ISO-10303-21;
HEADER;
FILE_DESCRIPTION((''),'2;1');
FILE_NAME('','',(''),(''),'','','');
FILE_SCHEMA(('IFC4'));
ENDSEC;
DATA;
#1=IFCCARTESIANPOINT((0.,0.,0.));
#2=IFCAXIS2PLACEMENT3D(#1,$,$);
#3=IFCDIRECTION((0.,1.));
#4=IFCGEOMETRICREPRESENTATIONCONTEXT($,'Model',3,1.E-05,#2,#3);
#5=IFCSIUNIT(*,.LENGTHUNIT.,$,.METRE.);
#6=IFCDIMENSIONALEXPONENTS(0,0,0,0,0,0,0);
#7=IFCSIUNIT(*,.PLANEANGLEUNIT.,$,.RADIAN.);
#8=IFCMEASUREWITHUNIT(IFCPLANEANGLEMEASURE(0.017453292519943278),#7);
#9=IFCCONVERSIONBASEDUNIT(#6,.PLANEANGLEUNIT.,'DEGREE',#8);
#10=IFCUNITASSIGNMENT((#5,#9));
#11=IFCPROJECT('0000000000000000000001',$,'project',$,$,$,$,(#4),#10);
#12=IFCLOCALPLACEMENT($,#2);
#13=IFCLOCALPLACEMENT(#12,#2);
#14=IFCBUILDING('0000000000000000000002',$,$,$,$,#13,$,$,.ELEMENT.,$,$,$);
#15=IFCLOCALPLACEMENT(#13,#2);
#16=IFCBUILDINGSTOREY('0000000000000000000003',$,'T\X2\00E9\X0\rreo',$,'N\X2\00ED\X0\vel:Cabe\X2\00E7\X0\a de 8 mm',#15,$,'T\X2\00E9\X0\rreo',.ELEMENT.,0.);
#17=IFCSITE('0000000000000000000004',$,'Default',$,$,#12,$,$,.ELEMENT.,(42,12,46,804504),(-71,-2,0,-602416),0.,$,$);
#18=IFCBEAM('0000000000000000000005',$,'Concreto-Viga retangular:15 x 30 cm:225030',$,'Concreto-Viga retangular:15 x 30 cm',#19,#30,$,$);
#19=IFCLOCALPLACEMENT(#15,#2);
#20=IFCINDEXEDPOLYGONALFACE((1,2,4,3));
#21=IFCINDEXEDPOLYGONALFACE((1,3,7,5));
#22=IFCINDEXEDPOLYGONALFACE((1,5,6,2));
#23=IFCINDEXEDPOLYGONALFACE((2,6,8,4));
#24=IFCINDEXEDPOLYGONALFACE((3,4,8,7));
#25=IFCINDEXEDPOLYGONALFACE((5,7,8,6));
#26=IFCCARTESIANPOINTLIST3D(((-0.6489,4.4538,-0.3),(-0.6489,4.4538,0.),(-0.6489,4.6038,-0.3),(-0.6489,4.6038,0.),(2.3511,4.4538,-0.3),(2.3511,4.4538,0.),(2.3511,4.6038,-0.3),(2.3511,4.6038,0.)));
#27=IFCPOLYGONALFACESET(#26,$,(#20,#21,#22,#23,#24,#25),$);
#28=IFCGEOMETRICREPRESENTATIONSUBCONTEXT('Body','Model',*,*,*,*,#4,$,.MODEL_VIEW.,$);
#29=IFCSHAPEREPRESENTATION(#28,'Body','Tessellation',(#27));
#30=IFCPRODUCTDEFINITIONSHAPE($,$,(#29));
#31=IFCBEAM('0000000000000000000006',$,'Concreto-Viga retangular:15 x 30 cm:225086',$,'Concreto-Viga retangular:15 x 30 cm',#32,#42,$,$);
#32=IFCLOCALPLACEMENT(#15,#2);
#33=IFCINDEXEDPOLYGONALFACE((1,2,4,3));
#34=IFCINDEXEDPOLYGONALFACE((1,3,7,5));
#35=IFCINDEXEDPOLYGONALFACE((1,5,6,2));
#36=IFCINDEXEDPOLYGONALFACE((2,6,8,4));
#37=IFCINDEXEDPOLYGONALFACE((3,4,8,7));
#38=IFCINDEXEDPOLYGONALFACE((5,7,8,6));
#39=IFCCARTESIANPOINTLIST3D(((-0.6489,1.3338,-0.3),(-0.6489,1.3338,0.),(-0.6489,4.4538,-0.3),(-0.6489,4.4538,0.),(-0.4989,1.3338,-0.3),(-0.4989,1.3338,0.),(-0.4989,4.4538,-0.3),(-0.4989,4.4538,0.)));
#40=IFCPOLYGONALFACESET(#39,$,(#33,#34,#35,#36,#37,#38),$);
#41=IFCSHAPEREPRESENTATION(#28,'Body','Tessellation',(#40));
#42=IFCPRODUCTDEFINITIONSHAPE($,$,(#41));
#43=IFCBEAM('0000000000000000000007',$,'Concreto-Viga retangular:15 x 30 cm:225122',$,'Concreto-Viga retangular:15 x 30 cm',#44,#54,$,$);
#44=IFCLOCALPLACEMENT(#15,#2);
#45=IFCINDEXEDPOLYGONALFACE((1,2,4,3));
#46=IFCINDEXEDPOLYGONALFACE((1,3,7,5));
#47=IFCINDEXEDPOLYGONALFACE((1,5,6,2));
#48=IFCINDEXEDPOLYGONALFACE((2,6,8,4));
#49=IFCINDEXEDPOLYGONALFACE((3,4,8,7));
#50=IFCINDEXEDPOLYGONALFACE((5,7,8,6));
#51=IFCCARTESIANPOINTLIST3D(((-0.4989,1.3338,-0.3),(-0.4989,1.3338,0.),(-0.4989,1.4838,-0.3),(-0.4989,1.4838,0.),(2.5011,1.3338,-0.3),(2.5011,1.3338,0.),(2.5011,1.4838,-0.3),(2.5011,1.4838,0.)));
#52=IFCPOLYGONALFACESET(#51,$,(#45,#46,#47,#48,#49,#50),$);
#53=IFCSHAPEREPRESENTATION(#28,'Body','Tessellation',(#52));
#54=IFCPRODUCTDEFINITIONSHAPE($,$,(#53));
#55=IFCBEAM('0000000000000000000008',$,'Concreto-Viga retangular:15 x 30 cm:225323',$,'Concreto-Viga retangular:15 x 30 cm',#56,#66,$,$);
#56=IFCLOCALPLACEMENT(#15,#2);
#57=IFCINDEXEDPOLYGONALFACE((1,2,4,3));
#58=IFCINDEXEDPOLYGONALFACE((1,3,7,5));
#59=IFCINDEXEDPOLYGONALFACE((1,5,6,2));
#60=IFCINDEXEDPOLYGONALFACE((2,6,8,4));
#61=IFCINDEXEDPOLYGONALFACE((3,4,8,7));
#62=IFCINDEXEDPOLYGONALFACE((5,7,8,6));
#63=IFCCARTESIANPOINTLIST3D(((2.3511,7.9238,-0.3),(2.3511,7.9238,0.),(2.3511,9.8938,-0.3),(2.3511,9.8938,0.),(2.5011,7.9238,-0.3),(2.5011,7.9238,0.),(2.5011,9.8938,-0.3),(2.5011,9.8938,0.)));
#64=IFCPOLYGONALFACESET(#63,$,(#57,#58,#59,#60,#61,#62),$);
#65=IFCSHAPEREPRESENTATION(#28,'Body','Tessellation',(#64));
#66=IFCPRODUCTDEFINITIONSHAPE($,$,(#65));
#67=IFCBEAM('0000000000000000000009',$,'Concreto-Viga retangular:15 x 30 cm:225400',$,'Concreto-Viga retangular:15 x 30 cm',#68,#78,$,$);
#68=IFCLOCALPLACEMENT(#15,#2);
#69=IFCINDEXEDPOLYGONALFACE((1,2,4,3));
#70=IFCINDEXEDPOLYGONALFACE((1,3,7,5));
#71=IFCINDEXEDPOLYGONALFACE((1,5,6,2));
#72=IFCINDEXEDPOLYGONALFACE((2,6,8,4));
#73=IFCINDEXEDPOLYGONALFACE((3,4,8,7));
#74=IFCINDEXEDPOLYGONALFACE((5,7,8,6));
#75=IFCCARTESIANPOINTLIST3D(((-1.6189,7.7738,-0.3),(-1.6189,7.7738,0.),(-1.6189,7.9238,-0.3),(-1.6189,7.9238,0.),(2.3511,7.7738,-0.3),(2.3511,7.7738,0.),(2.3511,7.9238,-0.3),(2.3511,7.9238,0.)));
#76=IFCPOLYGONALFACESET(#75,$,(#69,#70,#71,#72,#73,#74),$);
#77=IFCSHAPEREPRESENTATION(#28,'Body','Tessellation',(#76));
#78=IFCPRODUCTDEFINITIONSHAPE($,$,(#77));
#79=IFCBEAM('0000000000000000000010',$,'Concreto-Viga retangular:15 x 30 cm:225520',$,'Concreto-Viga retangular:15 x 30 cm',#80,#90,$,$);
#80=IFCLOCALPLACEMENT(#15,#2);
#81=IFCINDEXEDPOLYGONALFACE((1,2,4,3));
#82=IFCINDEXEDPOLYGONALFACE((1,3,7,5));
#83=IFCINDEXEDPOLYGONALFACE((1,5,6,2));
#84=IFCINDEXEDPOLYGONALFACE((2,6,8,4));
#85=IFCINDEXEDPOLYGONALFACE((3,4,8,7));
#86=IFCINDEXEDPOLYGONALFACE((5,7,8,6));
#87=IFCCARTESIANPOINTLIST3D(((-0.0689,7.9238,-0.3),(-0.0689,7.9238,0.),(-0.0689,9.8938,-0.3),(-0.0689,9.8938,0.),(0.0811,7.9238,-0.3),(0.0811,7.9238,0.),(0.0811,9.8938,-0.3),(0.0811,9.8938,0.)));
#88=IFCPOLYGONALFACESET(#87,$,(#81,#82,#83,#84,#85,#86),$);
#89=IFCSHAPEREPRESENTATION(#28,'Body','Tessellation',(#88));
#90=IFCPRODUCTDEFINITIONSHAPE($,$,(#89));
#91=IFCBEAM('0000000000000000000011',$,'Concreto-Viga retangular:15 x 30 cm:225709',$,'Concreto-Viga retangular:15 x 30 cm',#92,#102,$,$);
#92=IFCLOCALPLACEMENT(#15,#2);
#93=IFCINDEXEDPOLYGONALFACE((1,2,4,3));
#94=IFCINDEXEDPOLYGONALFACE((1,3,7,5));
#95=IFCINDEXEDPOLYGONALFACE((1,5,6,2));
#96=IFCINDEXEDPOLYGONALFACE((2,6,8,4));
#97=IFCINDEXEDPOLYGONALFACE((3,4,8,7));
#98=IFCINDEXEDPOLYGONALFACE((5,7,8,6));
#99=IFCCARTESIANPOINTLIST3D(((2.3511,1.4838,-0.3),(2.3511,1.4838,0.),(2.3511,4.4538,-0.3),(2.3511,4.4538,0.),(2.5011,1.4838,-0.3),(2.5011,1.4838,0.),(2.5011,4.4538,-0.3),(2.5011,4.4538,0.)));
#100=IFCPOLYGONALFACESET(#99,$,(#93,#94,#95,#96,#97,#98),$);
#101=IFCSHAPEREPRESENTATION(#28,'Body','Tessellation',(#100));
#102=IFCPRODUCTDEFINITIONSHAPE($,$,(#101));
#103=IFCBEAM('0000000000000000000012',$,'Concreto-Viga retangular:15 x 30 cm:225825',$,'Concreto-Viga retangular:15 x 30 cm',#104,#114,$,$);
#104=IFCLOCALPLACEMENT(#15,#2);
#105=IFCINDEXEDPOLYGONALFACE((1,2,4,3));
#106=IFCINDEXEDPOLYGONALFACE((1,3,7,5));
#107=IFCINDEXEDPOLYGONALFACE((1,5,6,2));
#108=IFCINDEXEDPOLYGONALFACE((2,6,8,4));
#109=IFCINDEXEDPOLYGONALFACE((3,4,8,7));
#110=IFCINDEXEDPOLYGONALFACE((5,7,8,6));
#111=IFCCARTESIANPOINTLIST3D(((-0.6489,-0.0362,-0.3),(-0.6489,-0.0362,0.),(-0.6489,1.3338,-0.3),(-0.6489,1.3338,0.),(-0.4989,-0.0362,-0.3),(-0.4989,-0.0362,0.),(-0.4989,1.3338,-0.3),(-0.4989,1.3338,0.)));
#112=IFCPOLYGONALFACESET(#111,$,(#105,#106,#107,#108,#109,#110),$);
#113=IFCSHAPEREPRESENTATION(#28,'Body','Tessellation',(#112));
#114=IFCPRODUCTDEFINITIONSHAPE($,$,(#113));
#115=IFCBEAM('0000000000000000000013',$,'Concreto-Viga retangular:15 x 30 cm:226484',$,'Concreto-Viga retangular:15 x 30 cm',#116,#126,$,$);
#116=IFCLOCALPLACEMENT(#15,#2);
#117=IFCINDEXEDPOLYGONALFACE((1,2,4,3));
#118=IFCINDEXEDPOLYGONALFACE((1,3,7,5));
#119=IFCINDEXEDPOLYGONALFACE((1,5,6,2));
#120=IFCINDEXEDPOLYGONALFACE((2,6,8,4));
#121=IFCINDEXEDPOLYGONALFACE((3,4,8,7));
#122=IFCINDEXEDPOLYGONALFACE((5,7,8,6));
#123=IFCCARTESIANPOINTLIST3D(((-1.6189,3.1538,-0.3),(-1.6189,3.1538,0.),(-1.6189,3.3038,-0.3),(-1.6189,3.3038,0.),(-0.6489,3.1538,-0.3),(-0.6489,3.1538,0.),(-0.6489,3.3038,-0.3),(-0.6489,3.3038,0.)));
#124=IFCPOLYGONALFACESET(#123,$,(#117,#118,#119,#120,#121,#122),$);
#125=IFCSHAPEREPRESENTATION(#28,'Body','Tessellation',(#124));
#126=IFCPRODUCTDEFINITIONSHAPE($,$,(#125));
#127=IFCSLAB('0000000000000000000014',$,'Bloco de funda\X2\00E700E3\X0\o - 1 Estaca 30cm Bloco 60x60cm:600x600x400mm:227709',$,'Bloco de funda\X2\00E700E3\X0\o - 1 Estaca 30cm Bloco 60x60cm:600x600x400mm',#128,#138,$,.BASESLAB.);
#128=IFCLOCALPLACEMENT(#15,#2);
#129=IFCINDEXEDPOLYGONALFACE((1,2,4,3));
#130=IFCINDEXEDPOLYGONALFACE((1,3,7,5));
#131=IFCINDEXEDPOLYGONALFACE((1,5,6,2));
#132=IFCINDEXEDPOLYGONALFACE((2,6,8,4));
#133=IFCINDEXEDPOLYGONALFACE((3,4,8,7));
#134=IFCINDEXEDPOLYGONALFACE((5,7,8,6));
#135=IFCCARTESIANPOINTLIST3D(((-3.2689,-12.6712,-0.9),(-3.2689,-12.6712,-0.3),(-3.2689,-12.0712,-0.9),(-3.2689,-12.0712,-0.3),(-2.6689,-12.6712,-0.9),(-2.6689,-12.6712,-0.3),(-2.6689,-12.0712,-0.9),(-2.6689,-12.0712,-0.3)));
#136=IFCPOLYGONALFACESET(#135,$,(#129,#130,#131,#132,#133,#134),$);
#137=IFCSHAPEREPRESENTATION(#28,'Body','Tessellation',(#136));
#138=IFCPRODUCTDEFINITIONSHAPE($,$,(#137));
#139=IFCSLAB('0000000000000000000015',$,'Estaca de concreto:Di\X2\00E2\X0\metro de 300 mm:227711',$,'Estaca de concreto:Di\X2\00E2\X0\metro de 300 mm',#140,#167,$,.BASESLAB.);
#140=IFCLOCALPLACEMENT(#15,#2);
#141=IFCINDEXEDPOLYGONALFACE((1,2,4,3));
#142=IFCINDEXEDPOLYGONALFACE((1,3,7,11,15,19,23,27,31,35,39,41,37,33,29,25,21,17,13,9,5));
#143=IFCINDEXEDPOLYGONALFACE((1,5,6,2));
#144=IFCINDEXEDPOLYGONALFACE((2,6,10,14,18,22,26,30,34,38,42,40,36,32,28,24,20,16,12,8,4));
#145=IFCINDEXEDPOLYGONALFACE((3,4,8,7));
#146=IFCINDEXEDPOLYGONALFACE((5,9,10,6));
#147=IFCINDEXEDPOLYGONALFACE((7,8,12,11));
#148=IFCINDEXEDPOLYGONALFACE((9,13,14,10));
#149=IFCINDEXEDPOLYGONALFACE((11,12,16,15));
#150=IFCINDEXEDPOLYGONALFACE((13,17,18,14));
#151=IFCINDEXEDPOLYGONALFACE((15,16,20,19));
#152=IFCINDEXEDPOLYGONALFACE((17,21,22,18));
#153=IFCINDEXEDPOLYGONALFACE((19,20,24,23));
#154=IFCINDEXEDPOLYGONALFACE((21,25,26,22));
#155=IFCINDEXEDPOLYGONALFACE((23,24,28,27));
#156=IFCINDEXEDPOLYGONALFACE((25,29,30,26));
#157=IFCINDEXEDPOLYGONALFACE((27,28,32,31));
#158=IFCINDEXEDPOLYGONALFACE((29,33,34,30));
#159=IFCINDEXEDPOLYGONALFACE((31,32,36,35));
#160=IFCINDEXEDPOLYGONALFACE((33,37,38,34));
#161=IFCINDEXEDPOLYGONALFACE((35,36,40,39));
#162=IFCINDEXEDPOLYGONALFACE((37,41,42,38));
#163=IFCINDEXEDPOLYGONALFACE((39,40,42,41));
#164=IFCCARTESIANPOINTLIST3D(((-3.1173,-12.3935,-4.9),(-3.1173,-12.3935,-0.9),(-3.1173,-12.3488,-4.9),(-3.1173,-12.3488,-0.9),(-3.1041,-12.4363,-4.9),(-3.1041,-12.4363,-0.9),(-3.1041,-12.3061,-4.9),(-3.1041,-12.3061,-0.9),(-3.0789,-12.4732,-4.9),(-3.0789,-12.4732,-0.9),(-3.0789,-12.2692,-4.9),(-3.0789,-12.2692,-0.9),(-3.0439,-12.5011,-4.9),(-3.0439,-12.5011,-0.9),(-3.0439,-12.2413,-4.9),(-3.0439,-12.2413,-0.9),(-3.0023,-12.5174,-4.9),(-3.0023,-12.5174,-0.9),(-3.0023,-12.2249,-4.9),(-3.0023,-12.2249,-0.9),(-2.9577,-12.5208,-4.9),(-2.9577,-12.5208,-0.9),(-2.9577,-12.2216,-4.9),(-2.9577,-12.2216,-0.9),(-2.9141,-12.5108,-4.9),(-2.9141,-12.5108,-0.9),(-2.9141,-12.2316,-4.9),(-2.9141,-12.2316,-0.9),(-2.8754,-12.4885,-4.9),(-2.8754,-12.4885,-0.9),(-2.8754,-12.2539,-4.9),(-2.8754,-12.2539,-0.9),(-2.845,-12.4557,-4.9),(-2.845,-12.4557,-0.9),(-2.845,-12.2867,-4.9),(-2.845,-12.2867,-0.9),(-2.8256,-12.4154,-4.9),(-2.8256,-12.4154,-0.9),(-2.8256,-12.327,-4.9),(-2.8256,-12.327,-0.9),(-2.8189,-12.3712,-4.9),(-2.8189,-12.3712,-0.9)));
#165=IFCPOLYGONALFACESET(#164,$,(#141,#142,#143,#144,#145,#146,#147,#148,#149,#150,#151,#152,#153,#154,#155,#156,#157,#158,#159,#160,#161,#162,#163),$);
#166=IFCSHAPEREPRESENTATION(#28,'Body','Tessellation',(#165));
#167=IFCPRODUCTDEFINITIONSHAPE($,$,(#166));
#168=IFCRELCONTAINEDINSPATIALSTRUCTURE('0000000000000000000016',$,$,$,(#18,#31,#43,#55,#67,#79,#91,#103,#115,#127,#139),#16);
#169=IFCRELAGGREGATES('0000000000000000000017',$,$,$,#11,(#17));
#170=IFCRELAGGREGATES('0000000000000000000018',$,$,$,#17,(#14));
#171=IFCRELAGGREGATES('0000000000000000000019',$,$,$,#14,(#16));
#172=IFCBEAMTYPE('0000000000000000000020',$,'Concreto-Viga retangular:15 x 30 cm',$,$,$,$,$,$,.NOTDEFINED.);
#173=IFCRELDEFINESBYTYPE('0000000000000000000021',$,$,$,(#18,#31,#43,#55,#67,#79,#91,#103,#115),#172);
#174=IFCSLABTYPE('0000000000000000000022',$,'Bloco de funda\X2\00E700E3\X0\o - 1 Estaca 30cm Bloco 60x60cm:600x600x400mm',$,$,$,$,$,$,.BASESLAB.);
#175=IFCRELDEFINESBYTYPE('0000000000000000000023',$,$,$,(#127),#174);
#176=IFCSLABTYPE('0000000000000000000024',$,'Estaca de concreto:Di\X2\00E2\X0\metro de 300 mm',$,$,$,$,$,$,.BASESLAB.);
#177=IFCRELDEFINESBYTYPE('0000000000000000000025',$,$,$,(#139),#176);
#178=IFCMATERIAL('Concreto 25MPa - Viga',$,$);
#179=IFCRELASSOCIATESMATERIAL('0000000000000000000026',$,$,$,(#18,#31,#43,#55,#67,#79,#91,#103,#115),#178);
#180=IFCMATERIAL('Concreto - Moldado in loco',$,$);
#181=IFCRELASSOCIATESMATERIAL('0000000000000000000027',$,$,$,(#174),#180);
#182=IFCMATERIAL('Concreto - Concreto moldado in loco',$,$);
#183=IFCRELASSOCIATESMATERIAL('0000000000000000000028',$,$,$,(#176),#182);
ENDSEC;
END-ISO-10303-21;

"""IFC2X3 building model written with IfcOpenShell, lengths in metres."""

from ifc_helpers import new_model, entity, si_unit, converted_unit, direction, frame, frame_2d, origin, origin_2d_with_axis, place, context, subcontext, project, spatial, rectangle, circle, extrude, material, type_object, element, save


model = new_model("IFC2X3")

# Units and contexts
model_context = context("Model", 3, precision=1e-05, world=origin(), true_north=direction((0.0, 1.0)))
body_context = subcontext(model_context, "Body", "Model", "MODEL_VIEW")
ifc_project = project(units=[si_unit("LENGTHUNIT", "METRE"), converted_unit("PLANEANGLEUNIT", "DEGREE", entity("IfcPlaneAngleMeasure", 0.017453292519943278), si_unit("PLANEANGLEUNIT", "RADIAN"), dimensions=[0, 0, 0, 0, 0, 0, 0])], contexts=[model_context])

# Site, building, storey
site_placement = place(None, origin())
site = spatial("IfcSite", under=ifc_project, at=site_placement, Name="Default", CompositionType="ELEMENT", RefLatitude=(42, 12, 46, 804504), RefLongitude=(-71, -2, 0, -602416), RefElevation=0.0)
building_placement = place(site_placement, origin())
building = spatial("IfcBuilding", under=site, at=building_placement, CompositionType="ELEMENT")
storey_placement = place(building_placement, origin())
storey = spatial("IfcBuildingStorey", under=building, at=storey_placement, Name="Térreo", ObjectType="Nível:Cabeça de 8 mm", LongName="Térreo", CompositionType="ELEMENT", Elevation=0.0)

# Beams
ifc_material_1 = material(Name="Concreto 25MPa - Viga")
beam_type = type_object("IfcBeamType", Name="Concreto-Viga retangular:15 x 30 cm", PredefinedType="NOTDEFINED")
beam_1_placement = place(storey_placement, frame((2.4261, 4.5288, 0.0), z_axis=(0.0, 0.0, 1.0), x_axis=(-1.0, 0.0, 0.0)))
element("IfcBeam", 1, at=beam_1_placement, inside=storey, type_object=beam_type, material=ifc_material_1, Name="Concreto-Viga retangular:15 x 30 cm:225030", ObjectType="Concreto-Viga retangular:15 x 30 cm", context=body_context, shape_type="SweptSolid", body=[
    extrude(rectangle(XDim=0.3, YDim=0.15, at=frame_2d((0.0, 0.0), x_axis=(1.0, 0.0))), frame((0.075, 0.0, -0.15), z_axis=(1.0, 0.0, 0.0), x_axis=(0.0, 0.0, -1.0)), (0.0, 0.0, 1.0), 3.0),
])
beam_2_placement = place(storey_placement, frame((-0.5739, 4.5288, 0.0), z_axis=(0.0, 0.0, 1.0), x_axis=(0.0, -1.0, 0.0)))
element("IfcBeam", 2, at=beam_2_placement, inside=storey, type_object=beam_type, material=ifc_material_1, Name="Concreto-Viga retangular:15 x 30 cm:225086", ObjectType="Concreto-Viga retangular:15 x 30 cm", context=body_context, shape_type="SweptSolid", body=[
    extrude(rectangle(XDim=0.3, YDim=0.15, at=frame_2d((0.0, 0.0), x_axis=(1.0, 0.0))), frame((0.075, 0.0, -0.15), z_axis=(1.0, 0.0, 0.0), x_axis=(0.0, 0.0, -1.0)), (0.0, 0.0, 1.0), 3.12),
])
beam_3_placement = place(storey_placement, frame((-0.5739, 1.4088, 0.0)))
element("IfcBeam", 3, at=beam_3_placement, inside=storey, type_object=beam_type, material=ifc_material_1, Name="Concreto-Viga retangular:15 x 30 cm:225122", ObjectType="Concreto-Viga retangular:15 x 30 cm", context=body_context, shape_type="SweptSolid", body=[
    extrude(rectangle(XDim=0.3, YDim=0.15, at=frame_2d((0.0, 0.0), x_axis=(1.0, 0.0))), frame((0.075, 0.0, -0.15), z_axis=(1.0, 0.0, 0.0), x_axis=(0.0, 0.0, -1.0)), (0.0, 0.0, 1.0), 3.0),
])
beam_4_placement = place(storey_placement, frame((2.4261, 9.9688, 0.0), z_axis=(0.0, 0.0, 1.0), x_axis=(0.0, -1.0, 0.0)))
element("IfcBeam", 4, at=beam_4_placement, inside=storey, type_object=beam_type, material=ifc_material_1, Name="Concreto-Viga retangular:15 x 30 cm:225323", ObjectType="Concreto-Viga retangular:15 x 30 cm", context=body_context, shape_type="SweptSolid", body=[
    extrude(rectangle(XDim=0.3, YDim=0.15, at=frame_2d((0.0, 0.0), x_axis=(1.0, 0.0))), frame((0.075, 0.0, -0.15), z_axis=(1.0, 0.0, 0.0), x_axis=(0.0, 0.0, -1.0)), (0.0, 0.0, 1.0), 1.97),
])
beam_5_placement = place(storey_placement, frame((-1.6939, 7.8488, 0.0)))
element("IfcBeam", 5, at=beam_5_placement, inside=storey, type_object=beam_type, material=ifc_material_1, Name="Concreto-Viga retangular:15 x 30 cm:225400", ObjectType="Concreto-Viga retangular:15 x 30 cm", context=body_context, shape_type="SweptSolid", body=[
    extrude(rectangle(XDim=0.3, YDim=0.15, at=frame_2d((0.0, 0.0), x_axis=(1.0, 0.0))), frame((0.075, 0.0, -0.15), z_axis=(1.0, 0.0, 0.0), x_axis=(0.0, 0.0, -1.0)), (0.0, 0.0, 1.0), 3.97),
])
beam_6_placement = place(storey_placement, frame((0.0061, 7.8488, 0.0), z_axis=(0.0, 0.0, 1.0), x_axis=(0.0, 1.0, 0.0)))
element("IfcBeam", 6, at=beam_6_placement, inside=storey, type_object=beam_type, material=ifc_material_1, Name="Concreto-Viga retangular:15 x 30 cm:225520", ObjectType="Concreto-Viga retangular:15 x 30 cm", context=body_context, shape_type="SweptSolid", body=[
    extrude(rectangle(XDim=0.3, YDim=0.15, at=frame_2d((0.0, 0.0), x_axis=(1.0, 0.0))), frame((0.075, 0.0, -0.15), z_axis=(1.0, 0.0, 0.0), x_axis=(0.0, 0.0, -1.0)), (0.0, 0.0, 1.0), 1.97),
])
beam_7_placement = place(storey_placement, frame((2.4261, 1.4088, 0.0), z_axis=(0.0, 0.0, 1.0), x_axis=(0.0, 1.0, 0.0)))
element("IfcBeam", 7, at=beam_7_placement, inside=storey, type_object=beam_type, material=ifc_material_1, Name="Concreto-Viga retangular:15 x 30 cm:225709", ObjectType="Concreto-Viga retangular:15 x 30 cm", context=body_context, shape_type="SweptSolid", body=[
    extrude(rectangle(XDim=0.3, YDim=0.15, at=frame_2d((0.0, 0.0), x_axis=(1.0, 0.0))), frame((0.075, 0.0, -0.15), z_axis=(1.0, 0.0, 0.0), x_axis=(0.0, 0.0, -1.0)), (0.0, 0.0, 1.0), 2.97),
])
beam_8_placement = place(storey_placement, frame((-0.5739, 1.4088, 0.0), z_axis=(0.0, 0.0, 1.0), x_axis=(0.0, -1.0, 0.0)))
element("IfcBeam", 8, at=beam_8_placement, inside=storey, type_object=beam_type, material=ifc_material_1, Name="Concreto-Viga retangular:15 x 30 cm:225825", ObjectType="Concreto-Viga retangular:15 x 30 cm", context=body_context, shape_type="SweptSolid", body=[
    extrude(rectangle(XDim=0.3, YDim=0.15, at=frame_2d((0.0, 0.0), x_axis=(1.0, 0.0))), frame((0.075, 0.0, -0.15), z_axis=(1.0, 0.0, 0.0), x_axis=(0.0, 0.0, -1.0)), (0.0, 0.0, 1.0), 1.37),
])
beam_9_placement = place(storey_placement, frame((-1.6939, 3.2288, 0.0)))
element("IfcBeam", 9, at=beam_9_placement, inside=storey, type_object=beam_type, material=ifc_material_1, Name="Concreto-Viga retangular:15 x 30 cm:226484", ObjectType="Concreto-Viga retangular:15 x 30 cm", context=body_context, shape_type="SweptSolid", body=[
    extrude(rectangle(XDim=0.3, YDim=0.15, at=frame_2d((0.0, 0.0), x_axis=(1.0, 0.0))), frame((0.075, 0.0, -0.15), z_axis=(1.0, 0.0, 0.0), x_axis=(0.0, 0.0, -1.0)), (0.0, 0.0, 1.0), 0.97),
])

# Slabs
ifc_material_2 = material(Name="Concreto - Moldado in loco")
slab_type_1 = type_object("IfcSlabType", Name="Bloco de fundação - 1 Estaca 30cm Bloco 60x60cm:600x600x400mm", PredefinedType="BASESLAB", material=ifc_material_2)
slab_1_placement = place(storey_placement, origin())
element("IfcSlab", 10, at=slab_1_placement, inside=storey, type_object=slab_type_1, Name="Bloco de fundação - 1 Estaca 30cm Bloco 60x60cm:600x600x400mm:227709", ObjectType="Bloco de fundação - 1 Estaca 30cm Bloco 60x60cm:600x600x400mm", PredefinedType="BASESLAB", context=body_context, shape_type="SweptSolid", body=[
    extrude(rectangle(XDim=0.6, YDim=0.6, at=frame_2d((0.0, 0.0), x_axis=(1.0, 0.0))), frame((-2.9689, -12.3712, -0.9), z_axis=(0.0, 0.0, 1.0), x_axis=(-1.0, 0.0, 0.0)), (0.0, 0.0, 1.0), 0.6),
])
ifc_material_3 = material(Name="Concreto - Concreto moldado in loco")
slab_type_2 = type_object("IfcSlabType", Name="Estaca de concreto:Diâmetro de 300 mm", PredefinedType="BASESLAB", material=ifc_material_3)
slab_2_placement = place(storey_placement, origin())
element("IfcSlab", 11, at=slab_2_placement, inside=storey, type_object=slab_type_2, Name="Estaca de concreto:Diâmetro de 300 mm:227711", ObjectType="Estaca de concreto:Diâmetro de 300 mm", PredefinedType="BASESLAB", context=body_context, shape_type="SweptSolid", body=[
    extrude(circle(Radius=0.15, at=origin_2d_with_axis()), frame((-2.9689, -12.3712, -4.9)), (0.0, 0.0, 1.0), 4.0),
])

save(model, "model.ifc")
